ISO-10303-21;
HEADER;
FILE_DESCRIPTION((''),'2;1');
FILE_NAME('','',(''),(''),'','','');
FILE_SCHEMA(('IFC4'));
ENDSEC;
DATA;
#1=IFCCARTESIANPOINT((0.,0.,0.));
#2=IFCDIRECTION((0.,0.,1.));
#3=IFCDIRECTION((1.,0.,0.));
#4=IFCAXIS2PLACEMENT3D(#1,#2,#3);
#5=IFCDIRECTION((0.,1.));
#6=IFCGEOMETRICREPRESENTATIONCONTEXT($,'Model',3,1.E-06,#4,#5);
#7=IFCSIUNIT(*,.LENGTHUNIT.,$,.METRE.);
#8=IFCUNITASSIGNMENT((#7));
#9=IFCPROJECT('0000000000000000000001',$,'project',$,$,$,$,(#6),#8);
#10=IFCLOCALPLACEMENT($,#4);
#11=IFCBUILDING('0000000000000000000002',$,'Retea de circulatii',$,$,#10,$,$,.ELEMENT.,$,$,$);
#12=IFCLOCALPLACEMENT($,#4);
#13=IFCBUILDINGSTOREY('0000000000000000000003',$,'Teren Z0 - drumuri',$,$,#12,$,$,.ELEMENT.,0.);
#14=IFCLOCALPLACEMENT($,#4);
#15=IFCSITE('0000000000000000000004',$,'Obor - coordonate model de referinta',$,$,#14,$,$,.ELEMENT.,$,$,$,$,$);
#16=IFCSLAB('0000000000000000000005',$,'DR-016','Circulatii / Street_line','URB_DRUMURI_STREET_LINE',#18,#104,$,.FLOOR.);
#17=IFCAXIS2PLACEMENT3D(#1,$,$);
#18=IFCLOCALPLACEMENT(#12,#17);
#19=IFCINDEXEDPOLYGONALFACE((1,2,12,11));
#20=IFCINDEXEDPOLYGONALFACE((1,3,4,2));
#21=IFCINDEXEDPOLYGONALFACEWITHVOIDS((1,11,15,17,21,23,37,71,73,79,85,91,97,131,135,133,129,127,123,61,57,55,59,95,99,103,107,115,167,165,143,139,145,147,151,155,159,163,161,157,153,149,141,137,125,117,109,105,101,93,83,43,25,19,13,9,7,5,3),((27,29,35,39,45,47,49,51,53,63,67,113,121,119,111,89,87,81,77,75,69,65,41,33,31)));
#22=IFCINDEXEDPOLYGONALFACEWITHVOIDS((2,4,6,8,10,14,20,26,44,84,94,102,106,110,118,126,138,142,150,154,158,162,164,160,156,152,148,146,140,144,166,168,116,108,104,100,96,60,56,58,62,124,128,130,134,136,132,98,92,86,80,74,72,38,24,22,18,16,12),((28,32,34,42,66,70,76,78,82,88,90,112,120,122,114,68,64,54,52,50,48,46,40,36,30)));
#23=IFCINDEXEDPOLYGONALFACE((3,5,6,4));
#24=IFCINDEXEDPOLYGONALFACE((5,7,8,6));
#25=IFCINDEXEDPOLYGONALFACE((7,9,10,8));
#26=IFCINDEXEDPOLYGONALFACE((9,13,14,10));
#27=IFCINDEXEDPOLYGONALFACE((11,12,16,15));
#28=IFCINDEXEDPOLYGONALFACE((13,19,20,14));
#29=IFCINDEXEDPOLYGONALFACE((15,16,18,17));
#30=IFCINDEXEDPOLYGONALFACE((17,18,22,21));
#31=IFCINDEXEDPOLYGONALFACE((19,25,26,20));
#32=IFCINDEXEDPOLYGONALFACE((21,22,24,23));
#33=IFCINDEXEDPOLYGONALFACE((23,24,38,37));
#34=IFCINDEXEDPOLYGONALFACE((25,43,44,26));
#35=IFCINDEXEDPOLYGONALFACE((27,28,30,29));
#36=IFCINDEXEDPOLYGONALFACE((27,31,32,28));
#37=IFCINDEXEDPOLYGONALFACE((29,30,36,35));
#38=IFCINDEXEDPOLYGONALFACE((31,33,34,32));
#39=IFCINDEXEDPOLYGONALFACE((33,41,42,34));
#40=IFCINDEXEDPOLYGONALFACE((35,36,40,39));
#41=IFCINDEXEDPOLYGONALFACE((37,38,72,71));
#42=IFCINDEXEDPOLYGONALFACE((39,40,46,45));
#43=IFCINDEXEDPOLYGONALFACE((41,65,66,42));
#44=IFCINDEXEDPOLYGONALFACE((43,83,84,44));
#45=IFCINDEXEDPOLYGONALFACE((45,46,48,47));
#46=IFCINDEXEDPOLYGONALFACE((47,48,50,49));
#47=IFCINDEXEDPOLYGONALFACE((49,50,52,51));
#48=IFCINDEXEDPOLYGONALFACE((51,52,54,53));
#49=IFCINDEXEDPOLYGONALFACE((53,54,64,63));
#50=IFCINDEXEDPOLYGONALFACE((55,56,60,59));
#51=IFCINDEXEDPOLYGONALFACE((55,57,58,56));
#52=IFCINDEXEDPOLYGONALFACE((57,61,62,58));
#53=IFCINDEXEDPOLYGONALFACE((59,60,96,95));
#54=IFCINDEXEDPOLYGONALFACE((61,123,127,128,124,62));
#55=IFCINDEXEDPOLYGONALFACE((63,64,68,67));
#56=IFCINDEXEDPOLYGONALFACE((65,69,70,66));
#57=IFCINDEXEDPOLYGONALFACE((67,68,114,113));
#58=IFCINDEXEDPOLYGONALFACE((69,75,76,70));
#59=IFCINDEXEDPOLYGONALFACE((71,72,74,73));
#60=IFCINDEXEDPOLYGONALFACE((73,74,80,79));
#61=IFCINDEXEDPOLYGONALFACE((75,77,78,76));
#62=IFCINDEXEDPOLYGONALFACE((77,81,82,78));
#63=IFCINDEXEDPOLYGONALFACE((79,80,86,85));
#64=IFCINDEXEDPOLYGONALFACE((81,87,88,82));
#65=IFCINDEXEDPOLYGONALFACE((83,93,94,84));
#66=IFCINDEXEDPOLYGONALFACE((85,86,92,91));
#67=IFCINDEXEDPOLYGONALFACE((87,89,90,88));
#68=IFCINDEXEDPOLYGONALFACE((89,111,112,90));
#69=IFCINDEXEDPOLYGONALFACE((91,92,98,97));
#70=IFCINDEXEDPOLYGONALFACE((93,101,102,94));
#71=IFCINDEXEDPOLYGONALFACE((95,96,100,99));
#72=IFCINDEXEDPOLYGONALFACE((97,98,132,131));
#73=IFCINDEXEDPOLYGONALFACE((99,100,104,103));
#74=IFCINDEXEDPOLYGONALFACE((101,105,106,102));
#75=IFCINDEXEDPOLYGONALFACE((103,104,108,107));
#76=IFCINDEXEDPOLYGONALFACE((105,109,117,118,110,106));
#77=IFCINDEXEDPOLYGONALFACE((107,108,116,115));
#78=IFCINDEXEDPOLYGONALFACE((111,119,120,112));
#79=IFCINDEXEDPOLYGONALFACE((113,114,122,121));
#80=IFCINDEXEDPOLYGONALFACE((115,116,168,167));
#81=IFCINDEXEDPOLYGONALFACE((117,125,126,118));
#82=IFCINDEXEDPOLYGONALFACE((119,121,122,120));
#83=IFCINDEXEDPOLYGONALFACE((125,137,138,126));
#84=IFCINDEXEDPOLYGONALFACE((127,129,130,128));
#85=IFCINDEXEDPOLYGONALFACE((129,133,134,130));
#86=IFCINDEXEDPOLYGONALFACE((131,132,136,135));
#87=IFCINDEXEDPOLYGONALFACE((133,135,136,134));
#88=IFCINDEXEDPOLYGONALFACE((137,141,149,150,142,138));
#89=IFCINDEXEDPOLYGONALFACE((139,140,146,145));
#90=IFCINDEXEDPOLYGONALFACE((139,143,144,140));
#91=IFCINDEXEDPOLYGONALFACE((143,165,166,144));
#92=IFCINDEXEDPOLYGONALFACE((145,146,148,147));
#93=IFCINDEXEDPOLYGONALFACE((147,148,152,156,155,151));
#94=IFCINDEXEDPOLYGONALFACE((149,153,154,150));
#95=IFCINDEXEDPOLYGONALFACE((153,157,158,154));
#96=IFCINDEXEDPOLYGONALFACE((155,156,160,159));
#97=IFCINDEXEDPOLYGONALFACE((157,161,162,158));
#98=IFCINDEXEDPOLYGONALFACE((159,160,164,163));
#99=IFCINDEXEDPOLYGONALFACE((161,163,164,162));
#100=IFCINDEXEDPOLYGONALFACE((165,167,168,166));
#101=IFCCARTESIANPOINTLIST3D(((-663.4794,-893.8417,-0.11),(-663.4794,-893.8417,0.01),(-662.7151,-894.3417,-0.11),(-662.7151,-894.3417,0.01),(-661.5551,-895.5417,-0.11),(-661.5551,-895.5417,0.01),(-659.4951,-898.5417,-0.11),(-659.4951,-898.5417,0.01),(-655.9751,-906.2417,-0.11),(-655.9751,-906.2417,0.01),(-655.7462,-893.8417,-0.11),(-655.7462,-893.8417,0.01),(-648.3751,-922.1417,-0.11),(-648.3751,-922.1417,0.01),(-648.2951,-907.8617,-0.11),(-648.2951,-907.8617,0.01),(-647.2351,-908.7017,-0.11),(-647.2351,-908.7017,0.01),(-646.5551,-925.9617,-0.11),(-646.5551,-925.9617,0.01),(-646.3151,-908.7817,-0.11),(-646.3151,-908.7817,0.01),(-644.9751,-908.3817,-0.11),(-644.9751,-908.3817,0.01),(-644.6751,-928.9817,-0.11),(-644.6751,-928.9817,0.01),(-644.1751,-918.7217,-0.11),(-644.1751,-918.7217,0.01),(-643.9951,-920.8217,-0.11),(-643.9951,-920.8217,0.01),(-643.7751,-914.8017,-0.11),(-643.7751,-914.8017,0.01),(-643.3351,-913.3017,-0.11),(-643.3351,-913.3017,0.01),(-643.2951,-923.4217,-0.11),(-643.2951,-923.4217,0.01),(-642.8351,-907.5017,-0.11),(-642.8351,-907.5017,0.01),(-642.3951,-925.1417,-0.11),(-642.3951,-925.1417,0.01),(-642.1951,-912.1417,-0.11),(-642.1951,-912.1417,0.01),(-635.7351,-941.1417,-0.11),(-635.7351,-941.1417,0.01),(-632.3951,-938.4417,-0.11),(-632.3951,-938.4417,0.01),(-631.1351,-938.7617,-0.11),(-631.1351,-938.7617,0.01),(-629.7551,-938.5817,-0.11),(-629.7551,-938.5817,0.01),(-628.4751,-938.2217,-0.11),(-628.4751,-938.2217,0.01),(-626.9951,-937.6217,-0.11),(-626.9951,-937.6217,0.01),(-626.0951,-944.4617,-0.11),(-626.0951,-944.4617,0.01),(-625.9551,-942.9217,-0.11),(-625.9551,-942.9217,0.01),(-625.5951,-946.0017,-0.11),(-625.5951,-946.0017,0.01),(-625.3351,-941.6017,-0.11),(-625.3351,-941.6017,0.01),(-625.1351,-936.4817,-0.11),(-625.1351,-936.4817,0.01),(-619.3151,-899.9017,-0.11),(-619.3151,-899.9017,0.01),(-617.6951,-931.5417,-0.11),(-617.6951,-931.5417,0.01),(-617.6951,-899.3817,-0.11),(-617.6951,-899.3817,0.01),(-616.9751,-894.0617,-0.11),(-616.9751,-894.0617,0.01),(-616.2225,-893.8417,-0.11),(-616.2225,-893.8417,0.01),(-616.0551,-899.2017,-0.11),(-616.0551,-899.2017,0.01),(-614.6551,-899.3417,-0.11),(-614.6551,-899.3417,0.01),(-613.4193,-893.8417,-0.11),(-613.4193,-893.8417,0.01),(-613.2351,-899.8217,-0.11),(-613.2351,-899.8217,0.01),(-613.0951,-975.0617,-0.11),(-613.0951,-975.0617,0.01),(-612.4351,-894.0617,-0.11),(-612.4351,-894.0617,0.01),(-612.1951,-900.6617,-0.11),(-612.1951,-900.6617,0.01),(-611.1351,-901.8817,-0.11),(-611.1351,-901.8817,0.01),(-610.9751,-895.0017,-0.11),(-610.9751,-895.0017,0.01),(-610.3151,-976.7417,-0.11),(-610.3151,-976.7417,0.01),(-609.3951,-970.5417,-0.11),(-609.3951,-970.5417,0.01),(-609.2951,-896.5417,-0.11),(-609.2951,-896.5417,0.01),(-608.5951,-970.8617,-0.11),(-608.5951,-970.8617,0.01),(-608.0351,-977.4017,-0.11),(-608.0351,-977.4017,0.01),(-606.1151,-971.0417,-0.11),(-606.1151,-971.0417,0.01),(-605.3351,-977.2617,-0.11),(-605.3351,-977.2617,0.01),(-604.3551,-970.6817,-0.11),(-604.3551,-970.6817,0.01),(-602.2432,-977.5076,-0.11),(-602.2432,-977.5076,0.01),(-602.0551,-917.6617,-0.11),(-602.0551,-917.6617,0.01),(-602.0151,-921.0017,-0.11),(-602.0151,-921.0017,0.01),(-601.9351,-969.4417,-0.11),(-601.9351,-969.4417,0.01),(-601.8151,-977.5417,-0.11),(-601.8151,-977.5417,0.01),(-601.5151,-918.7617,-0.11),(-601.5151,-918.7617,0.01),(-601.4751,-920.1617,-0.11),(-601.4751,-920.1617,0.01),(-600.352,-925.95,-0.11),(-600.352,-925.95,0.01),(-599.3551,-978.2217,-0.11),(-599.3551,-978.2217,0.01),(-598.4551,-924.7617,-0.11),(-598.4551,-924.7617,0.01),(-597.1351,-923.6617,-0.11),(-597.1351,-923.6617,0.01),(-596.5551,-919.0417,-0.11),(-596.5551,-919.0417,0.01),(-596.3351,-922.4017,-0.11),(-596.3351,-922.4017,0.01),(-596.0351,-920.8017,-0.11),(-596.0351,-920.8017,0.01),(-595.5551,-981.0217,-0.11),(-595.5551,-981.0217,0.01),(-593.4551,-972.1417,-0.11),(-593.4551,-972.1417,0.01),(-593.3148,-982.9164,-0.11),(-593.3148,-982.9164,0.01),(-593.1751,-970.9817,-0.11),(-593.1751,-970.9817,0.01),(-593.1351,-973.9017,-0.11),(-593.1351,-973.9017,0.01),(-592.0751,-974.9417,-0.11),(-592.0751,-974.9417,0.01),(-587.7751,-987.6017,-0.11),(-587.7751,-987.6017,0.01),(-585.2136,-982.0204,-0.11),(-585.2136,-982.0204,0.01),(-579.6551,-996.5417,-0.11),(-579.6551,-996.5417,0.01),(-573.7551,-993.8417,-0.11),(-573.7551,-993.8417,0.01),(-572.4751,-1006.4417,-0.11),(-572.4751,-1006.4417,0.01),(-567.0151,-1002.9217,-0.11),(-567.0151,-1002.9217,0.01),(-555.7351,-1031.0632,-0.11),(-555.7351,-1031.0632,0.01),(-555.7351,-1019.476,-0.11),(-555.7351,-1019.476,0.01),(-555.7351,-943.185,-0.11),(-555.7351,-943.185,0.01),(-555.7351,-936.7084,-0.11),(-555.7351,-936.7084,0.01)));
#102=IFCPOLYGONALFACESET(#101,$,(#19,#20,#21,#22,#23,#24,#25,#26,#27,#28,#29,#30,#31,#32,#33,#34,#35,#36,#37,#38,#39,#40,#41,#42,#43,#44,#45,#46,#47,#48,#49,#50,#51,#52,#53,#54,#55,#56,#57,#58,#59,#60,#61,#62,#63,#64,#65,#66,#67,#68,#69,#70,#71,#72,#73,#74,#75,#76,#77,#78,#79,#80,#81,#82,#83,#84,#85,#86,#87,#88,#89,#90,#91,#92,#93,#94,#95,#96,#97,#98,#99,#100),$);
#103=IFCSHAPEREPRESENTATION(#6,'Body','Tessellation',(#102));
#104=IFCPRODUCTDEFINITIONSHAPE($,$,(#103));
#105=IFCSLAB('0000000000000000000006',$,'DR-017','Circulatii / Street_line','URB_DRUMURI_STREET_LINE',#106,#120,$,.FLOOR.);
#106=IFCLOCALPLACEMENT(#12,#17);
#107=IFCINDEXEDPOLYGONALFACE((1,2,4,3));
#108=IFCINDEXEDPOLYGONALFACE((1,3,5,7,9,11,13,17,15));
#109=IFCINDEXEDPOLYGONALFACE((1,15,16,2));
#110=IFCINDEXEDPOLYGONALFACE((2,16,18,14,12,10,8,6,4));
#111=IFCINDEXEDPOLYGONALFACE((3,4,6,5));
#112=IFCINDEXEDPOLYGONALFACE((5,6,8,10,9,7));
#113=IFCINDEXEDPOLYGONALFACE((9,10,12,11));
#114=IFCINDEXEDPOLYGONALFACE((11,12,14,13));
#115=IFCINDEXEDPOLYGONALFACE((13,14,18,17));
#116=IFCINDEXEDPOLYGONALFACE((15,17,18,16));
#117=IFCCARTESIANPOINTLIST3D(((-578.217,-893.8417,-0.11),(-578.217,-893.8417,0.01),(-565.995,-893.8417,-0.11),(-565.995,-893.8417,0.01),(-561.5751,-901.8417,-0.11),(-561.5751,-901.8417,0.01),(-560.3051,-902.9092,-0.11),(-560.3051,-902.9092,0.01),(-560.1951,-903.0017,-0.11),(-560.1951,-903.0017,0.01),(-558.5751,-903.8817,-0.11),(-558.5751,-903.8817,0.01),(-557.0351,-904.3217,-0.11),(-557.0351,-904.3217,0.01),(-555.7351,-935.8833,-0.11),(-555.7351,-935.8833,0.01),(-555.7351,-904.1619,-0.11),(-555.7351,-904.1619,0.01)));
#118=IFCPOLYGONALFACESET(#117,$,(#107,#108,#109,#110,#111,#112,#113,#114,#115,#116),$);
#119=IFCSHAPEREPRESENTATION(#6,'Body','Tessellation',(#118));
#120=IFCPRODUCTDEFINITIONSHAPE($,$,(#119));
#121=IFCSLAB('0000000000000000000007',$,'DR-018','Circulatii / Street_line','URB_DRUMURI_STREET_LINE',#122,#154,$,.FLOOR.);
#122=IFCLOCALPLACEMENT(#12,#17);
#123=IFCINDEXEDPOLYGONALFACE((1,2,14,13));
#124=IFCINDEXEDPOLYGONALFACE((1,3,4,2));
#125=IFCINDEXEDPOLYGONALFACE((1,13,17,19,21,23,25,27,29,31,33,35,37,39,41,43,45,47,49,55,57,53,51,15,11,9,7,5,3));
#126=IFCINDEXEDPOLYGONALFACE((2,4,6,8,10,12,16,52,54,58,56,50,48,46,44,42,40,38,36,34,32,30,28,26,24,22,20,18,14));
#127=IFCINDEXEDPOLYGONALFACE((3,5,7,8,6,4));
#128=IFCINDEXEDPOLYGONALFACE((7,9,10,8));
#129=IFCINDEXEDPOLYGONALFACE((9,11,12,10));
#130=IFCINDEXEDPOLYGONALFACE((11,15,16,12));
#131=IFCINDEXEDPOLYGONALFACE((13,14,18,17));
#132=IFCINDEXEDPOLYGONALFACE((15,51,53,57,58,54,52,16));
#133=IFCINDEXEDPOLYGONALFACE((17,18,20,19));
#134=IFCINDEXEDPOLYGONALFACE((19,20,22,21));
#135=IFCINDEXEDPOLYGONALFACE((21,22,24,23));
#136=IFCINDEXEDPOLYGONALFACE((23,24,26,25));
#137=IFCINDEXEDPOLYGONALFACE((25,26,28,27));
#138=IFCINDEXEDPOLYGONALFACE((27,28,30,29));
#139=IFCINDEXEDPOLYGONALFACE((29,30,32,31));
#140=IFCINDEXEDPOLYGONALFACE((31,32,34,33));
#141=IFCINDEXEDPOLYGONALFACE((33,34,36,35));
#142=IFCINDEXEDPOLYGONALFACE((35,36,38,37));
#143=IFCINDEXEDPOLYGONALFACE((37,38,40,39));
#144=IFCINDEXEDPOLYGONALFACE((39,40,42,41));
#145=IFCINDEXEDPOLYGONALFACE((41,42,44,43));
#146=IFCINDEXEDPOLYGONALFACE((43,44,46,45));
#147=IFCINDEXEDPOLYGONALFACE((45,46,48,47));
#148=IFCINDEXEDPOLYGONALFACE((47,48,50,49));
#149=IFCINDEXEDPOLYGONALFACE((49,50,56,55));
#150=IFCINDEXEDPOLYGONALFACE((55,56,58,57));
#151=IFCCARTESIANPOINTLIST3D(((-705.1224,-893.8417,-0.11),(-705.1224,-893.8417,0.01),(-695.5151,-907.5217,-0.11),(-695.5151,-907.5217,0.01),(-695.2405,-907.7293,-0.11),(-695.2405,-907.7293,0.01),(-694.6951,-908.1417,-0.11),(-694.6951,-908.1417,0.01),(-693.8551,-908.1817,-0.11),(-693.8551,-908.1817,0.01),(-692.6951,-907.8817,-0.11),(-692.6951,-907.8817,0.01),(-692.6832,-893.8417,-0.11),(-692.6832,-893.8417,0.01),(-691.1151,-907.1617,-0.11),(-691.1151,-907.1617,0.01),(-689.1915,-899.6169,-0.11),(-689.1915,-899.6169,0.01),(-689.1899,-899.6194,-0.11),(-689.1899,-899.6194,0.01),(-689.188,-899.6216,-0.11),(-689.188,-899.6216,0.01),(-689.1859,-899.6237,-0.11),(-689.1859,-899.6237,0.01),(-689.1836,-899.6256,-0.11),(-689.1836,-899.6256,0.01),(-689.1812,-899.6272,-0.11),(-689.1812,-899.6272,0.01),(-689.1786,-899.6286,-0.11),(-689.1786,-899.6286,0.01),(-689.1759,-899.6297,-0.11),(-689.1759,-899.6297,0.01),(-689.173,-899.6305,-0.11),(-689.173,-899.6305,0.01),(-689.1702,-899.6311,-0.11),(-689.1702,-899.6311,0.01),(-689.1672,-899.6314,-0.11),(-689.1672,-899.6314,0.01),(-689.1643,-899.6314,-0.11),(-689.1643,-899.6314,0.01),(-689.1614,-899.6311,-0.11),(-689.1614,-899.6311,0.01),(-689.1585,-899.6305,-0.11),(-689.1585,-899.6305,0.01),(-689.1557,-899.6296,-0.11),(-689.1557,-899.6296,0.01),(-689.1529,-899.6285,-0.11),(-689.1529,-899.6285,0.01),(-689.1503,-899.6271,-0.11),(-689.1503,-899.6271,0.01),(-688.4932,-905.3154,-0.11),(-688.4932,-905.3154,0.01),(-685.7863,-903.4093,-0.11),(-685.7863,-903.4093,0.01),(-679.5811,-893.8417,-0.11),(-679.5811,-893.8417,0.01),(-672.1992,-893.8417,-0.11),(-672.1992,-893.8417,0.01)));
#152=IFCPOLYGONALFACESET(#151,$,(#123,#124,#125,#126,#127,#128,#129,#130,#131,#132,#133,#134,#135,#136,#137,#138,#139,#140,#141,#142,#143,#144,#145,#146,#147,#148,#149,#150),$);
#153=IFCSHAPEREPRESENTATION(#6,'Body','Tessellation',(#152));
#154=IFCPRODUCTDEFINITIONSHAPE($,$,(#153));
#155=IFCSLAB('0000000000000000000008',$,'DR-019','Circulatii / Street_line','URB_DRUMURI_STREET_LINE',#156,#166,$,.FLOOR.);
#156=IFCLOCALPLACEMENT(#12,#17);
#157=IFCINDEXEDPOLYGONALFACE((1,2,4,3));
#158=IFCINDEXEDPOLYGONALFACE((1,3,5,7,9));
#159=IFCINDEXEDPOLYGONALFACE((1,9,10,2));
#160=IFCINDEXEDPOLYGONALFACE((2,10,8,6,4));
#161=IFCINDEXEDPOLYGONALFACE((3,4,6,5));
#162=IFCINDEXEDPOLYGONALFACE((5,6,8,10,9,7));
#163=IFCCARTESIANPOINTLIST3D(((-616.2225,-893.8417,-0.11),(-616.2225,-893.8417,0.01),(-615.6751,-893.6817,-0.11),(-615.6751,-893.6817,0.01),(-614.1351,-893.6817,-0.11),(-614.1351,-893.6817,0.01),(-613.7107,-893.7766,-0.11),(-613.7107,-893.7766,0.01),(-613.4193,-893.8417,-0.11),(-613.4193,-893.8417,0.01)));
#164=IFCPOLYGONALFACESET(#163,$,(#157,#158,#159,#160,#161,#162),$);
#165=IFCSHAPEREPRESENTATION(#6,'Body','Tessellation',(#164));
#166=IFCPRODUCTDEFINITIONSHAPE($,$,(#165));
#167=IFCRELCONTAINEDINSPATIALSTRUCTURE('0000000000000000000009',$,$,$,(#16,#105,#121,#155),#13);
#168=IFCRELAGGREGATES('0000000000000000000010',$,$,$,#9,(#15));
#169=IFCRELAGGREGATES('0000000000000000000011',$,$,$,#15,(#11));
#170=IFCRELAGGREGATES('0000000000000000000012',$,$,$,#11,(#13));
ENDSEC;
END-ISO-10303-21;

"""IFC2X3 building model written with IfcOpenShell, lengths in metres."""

from ifc_helpers import new_model, si_unit, direction, frame, origin_with_axes, place, context, project, spatial, polyline, outline, extrude, element, save


model = new_model("IFC2X3")

# Units and contexts
model_context = context("Model", 3, precision=1e-06, world=origin_with_axes(), true_north=direction((0.0, 1.0)))
ifc_project = project(units=[si_unit("LENGTHUNIT", "METRE")], contexts=[model_context])

# Site, building, storey
site_placement = place(None, origin_with_axes())
site = spatial("IfcSite", under=ifc_project, at=site_placement, Name="Obor - coordonate model de referinta", CompositionType="ELEMENT")
building_placement = place(None, origin_with_axes())
building = spatial("IfcBuilding", under=site, at=building_placement, Name="Retea de circulatii", CompositionType="ELEMENT")
storey_placement = place(None, origin_with_axes())
storey = spatial("IfcBuildingStorey", under=building, at=storey_placement, Name="Teren Z0 - drumuri", CompositionType="ELEMENT", Elevation=0.0)

# Slabs
slab_1_placement = place(None, origin_with_axes())
element("IfcSlab", 1, at=slab_1_placement, inside=storey, Name="DR-016", Description="Circulatii / Street_line", ObjectType="URB_DRUMURI_STREET_LINE", PredefinedType="FLOOR", context=model_context, shape_type="SweptSolid", body=[
    extrude(outline(polyline([(-605.3351, -977.2617), (-602.2432, -977.5076), (-601.8151, -977.5417), (-599.3551, -978.2217), (-595.5551, -981.0217), (-593.3148, -982.9164), (-587.7751, -987.6017), (-579.6551, -996.5417), (-572.4751, -1006.4417), (-555.7351, -1031.0632), (-555.7351, -1019.476), (-567.0151, -1002.9217), (-573.7551, -993.8417), (-585.2136, -982.0204), (-592.0751, -974.9417), (-593.1351, -973.9017), (-593.4551, -972.1417), (-593.1751, -970.9817), (-555.7351, -943.185), (-555.7351, -936.7084), (-601.9351, -969.4417), (-604.3551, -970.6817), (-606.1151, -971.0417), (-608.5951, -970.8617), (-609.3951, -970.5417), (-625.5951, -946.0017), (-626.0951, -944.4617), (-625.9551, -942.9217), (-625.3351, -941.6017), (-600.352, -925.95), (-598.4551, -924.7617), (-597.1351, -923.6617), (-596.3351, -922.4017), (-596.0351, -920.8017), (-596.5551, -919.0417), (-609.2951, -896.5417), (-610.9751, -895.0017), (-612.4351, -894.0617), (-613.4193, -893.8417), (-616.2225, -893.8417), (-616.9751, -894.0617), (-642.8351, -907.5017), (-644.9751, -908.3817), (-646.3151, -908.7817), (-647.2351, -908.7017), (-648.2951, -907.8617), (-655.7462, -893.8417), (-663.4794, -893.8417), (-662.7151, -894.3417), (-661.5551, -895.5417), (-659.4951, -898.5417), (-655.9751, -906.2417), (-648.3751, -922.1417), (-646.5551, -925.9617), (-644.6751, -928.9817), (-635.7351, -941.1417), (-613.0951, -975.0617), (-610.3151, -976.7417), (-608.0351, -977.4017), (-605.3351, -977.2617)]), holes=[polyline([(-632.3951, -938.4417), (-642.3951, -925.1417), (-643.2951, -923.4217), (-643.9951, -920.8217), (-644.1751, -918.7217), (-643.7751, -914.8017), (-643.3351, -913.3017), (-642.1951, -912.1417), (-619.3151, -899.9017), (-617.6951, -899.3817), (-616.0551, -899.2017), (-614.6551, -899.3417), (-613.2351, -899.8217), (-612.1951, -900.6617), (-611.1351, -901.8817), (-602.0551, -917.6617), (-601.5151, -918.7617), (-601.4751, -920.1617), (-602.0151, -921.0017), (-617.6951, -931.5417), (-625.1351, -936.4817), (-626.9951, -937.6217), (-628.4751, -938.2217), (-629.7551, -938.5817), (-631.1351, -938.7617), (-632.3951, -938.4417)])]), frame((0.0, 0.0, -0.11), z_axis=(0.0, 0.0, 1.0), x_axis=(1.0, 0.0, 0.0)), (0.0, 0.0, 1.0), 0.12),
])
slab_2_placement = place(None, origin_with_axes())
element("IfcSlab", 2, at=slab_2_placement, inside=storey, Name="DR-017", Description="Circulatii / Street_line", ObjectType="URB_DRUMURI_STREET_LINE", PredefinedType="FLOOR", context=model_context, shape_type="SweptSolid", body=[
    extrude(outline(polyline([(-561.5751, -901.8417), (-565.995, -893.8417), (-578.217, -893.8417), (-555.7351, -935.8833), (-555.7351, -904.1619), (-557.0351, -904.3217), (-558.5751, -903.8817), (-560.1951, -903.0017), (-560.3051, -902.9092), (-561.5751, -901.8417)])), frame((0.0, 0.0, -0.11), z_axis=(0.0, 0.0, 1.0), x_axis=(1.0, 0.0, 0.0)), (0.0, 0.0, 1.0), 0.12),
])
slab_3_placement = place(None, origin_with_axes())
element("IfcSlab", 3, at=slab_3_placement, inside=storey, Name="DR-018", Description="Circulatii / Street_line", ObjectType="URB_DRUMURI_STREET_LINE", PredefinedType="FLOOR", context=model_context, shape_type="SweptSolid", body=[
    extrude(outline(polyline([(-691.1151, -907.1617), (-688.4932, -905.3154), (-685.7863, -903.4093), (-672.1992, -893.8417), (-679.5811, -893.8417), (-689.1503, -899.6271), (-689.1529, -899.6285), (-689.1557, -899.6296), (-689.1585, -899.6305), (-689.1614, -899.6311), (-689.1643, -899.6314), (-689.1672, -899.6314), (-689.1702, -899.6311), (-689.173, -899.6305), (-689.1759, -899.6297), (-689.1786, -899.6286), (-689.1812, -899.6272), (-689.1836, -899.6256), (-689.1859, -899.6237), (-689.188, -899.6216), (-689.1899, -899.6194), (-689.1915, -899.6169), (-692.6832, -893.8417), (-705.1224, -893.8417), (-695.5151, -907.5217), (-695.2405, -907.7293), (-694.6951, -908.1417), (-693.8551, -908.1817), (-692.6951, -907.8817), (-691.1151, -907.1617)])), frame((0.0, 0.0, -0.11), z_axis=(0.0, 0.0, 1.0), x_axis=(1.0, 0.0, 0.0)), (0.0, 0.0, 1.0), 0.12),
])
slab_4_placement = place(None, origin_with_axes())
element("IfcSlab", 4, at=slab_4_placement, inside=storey, Name="DR-019", Description="Circulatii / Street_line", ObjectType="URB_DRUMURI_STREET_LINE", PredefinedType="FLOOR", context=model_context, shape_type="SweptSolid", body=[
    extrude(outline(polyline([(-613.7107, -893.7766), (-614.1351, -893.6817), (-615.6751, -893.6817), (-616.2225, -893.8417), (-613.4193, -893.8417), (-613.7107, -893.7766)])), frame((0.0, 0.0, -0.11), z_axis=(0.0, 0.0, 1.0), x_axis=(1.0, 0.0, 0.0)), (0.0, 0.0, 1.0), 0.12),
])

save(model, "model.ifc")
